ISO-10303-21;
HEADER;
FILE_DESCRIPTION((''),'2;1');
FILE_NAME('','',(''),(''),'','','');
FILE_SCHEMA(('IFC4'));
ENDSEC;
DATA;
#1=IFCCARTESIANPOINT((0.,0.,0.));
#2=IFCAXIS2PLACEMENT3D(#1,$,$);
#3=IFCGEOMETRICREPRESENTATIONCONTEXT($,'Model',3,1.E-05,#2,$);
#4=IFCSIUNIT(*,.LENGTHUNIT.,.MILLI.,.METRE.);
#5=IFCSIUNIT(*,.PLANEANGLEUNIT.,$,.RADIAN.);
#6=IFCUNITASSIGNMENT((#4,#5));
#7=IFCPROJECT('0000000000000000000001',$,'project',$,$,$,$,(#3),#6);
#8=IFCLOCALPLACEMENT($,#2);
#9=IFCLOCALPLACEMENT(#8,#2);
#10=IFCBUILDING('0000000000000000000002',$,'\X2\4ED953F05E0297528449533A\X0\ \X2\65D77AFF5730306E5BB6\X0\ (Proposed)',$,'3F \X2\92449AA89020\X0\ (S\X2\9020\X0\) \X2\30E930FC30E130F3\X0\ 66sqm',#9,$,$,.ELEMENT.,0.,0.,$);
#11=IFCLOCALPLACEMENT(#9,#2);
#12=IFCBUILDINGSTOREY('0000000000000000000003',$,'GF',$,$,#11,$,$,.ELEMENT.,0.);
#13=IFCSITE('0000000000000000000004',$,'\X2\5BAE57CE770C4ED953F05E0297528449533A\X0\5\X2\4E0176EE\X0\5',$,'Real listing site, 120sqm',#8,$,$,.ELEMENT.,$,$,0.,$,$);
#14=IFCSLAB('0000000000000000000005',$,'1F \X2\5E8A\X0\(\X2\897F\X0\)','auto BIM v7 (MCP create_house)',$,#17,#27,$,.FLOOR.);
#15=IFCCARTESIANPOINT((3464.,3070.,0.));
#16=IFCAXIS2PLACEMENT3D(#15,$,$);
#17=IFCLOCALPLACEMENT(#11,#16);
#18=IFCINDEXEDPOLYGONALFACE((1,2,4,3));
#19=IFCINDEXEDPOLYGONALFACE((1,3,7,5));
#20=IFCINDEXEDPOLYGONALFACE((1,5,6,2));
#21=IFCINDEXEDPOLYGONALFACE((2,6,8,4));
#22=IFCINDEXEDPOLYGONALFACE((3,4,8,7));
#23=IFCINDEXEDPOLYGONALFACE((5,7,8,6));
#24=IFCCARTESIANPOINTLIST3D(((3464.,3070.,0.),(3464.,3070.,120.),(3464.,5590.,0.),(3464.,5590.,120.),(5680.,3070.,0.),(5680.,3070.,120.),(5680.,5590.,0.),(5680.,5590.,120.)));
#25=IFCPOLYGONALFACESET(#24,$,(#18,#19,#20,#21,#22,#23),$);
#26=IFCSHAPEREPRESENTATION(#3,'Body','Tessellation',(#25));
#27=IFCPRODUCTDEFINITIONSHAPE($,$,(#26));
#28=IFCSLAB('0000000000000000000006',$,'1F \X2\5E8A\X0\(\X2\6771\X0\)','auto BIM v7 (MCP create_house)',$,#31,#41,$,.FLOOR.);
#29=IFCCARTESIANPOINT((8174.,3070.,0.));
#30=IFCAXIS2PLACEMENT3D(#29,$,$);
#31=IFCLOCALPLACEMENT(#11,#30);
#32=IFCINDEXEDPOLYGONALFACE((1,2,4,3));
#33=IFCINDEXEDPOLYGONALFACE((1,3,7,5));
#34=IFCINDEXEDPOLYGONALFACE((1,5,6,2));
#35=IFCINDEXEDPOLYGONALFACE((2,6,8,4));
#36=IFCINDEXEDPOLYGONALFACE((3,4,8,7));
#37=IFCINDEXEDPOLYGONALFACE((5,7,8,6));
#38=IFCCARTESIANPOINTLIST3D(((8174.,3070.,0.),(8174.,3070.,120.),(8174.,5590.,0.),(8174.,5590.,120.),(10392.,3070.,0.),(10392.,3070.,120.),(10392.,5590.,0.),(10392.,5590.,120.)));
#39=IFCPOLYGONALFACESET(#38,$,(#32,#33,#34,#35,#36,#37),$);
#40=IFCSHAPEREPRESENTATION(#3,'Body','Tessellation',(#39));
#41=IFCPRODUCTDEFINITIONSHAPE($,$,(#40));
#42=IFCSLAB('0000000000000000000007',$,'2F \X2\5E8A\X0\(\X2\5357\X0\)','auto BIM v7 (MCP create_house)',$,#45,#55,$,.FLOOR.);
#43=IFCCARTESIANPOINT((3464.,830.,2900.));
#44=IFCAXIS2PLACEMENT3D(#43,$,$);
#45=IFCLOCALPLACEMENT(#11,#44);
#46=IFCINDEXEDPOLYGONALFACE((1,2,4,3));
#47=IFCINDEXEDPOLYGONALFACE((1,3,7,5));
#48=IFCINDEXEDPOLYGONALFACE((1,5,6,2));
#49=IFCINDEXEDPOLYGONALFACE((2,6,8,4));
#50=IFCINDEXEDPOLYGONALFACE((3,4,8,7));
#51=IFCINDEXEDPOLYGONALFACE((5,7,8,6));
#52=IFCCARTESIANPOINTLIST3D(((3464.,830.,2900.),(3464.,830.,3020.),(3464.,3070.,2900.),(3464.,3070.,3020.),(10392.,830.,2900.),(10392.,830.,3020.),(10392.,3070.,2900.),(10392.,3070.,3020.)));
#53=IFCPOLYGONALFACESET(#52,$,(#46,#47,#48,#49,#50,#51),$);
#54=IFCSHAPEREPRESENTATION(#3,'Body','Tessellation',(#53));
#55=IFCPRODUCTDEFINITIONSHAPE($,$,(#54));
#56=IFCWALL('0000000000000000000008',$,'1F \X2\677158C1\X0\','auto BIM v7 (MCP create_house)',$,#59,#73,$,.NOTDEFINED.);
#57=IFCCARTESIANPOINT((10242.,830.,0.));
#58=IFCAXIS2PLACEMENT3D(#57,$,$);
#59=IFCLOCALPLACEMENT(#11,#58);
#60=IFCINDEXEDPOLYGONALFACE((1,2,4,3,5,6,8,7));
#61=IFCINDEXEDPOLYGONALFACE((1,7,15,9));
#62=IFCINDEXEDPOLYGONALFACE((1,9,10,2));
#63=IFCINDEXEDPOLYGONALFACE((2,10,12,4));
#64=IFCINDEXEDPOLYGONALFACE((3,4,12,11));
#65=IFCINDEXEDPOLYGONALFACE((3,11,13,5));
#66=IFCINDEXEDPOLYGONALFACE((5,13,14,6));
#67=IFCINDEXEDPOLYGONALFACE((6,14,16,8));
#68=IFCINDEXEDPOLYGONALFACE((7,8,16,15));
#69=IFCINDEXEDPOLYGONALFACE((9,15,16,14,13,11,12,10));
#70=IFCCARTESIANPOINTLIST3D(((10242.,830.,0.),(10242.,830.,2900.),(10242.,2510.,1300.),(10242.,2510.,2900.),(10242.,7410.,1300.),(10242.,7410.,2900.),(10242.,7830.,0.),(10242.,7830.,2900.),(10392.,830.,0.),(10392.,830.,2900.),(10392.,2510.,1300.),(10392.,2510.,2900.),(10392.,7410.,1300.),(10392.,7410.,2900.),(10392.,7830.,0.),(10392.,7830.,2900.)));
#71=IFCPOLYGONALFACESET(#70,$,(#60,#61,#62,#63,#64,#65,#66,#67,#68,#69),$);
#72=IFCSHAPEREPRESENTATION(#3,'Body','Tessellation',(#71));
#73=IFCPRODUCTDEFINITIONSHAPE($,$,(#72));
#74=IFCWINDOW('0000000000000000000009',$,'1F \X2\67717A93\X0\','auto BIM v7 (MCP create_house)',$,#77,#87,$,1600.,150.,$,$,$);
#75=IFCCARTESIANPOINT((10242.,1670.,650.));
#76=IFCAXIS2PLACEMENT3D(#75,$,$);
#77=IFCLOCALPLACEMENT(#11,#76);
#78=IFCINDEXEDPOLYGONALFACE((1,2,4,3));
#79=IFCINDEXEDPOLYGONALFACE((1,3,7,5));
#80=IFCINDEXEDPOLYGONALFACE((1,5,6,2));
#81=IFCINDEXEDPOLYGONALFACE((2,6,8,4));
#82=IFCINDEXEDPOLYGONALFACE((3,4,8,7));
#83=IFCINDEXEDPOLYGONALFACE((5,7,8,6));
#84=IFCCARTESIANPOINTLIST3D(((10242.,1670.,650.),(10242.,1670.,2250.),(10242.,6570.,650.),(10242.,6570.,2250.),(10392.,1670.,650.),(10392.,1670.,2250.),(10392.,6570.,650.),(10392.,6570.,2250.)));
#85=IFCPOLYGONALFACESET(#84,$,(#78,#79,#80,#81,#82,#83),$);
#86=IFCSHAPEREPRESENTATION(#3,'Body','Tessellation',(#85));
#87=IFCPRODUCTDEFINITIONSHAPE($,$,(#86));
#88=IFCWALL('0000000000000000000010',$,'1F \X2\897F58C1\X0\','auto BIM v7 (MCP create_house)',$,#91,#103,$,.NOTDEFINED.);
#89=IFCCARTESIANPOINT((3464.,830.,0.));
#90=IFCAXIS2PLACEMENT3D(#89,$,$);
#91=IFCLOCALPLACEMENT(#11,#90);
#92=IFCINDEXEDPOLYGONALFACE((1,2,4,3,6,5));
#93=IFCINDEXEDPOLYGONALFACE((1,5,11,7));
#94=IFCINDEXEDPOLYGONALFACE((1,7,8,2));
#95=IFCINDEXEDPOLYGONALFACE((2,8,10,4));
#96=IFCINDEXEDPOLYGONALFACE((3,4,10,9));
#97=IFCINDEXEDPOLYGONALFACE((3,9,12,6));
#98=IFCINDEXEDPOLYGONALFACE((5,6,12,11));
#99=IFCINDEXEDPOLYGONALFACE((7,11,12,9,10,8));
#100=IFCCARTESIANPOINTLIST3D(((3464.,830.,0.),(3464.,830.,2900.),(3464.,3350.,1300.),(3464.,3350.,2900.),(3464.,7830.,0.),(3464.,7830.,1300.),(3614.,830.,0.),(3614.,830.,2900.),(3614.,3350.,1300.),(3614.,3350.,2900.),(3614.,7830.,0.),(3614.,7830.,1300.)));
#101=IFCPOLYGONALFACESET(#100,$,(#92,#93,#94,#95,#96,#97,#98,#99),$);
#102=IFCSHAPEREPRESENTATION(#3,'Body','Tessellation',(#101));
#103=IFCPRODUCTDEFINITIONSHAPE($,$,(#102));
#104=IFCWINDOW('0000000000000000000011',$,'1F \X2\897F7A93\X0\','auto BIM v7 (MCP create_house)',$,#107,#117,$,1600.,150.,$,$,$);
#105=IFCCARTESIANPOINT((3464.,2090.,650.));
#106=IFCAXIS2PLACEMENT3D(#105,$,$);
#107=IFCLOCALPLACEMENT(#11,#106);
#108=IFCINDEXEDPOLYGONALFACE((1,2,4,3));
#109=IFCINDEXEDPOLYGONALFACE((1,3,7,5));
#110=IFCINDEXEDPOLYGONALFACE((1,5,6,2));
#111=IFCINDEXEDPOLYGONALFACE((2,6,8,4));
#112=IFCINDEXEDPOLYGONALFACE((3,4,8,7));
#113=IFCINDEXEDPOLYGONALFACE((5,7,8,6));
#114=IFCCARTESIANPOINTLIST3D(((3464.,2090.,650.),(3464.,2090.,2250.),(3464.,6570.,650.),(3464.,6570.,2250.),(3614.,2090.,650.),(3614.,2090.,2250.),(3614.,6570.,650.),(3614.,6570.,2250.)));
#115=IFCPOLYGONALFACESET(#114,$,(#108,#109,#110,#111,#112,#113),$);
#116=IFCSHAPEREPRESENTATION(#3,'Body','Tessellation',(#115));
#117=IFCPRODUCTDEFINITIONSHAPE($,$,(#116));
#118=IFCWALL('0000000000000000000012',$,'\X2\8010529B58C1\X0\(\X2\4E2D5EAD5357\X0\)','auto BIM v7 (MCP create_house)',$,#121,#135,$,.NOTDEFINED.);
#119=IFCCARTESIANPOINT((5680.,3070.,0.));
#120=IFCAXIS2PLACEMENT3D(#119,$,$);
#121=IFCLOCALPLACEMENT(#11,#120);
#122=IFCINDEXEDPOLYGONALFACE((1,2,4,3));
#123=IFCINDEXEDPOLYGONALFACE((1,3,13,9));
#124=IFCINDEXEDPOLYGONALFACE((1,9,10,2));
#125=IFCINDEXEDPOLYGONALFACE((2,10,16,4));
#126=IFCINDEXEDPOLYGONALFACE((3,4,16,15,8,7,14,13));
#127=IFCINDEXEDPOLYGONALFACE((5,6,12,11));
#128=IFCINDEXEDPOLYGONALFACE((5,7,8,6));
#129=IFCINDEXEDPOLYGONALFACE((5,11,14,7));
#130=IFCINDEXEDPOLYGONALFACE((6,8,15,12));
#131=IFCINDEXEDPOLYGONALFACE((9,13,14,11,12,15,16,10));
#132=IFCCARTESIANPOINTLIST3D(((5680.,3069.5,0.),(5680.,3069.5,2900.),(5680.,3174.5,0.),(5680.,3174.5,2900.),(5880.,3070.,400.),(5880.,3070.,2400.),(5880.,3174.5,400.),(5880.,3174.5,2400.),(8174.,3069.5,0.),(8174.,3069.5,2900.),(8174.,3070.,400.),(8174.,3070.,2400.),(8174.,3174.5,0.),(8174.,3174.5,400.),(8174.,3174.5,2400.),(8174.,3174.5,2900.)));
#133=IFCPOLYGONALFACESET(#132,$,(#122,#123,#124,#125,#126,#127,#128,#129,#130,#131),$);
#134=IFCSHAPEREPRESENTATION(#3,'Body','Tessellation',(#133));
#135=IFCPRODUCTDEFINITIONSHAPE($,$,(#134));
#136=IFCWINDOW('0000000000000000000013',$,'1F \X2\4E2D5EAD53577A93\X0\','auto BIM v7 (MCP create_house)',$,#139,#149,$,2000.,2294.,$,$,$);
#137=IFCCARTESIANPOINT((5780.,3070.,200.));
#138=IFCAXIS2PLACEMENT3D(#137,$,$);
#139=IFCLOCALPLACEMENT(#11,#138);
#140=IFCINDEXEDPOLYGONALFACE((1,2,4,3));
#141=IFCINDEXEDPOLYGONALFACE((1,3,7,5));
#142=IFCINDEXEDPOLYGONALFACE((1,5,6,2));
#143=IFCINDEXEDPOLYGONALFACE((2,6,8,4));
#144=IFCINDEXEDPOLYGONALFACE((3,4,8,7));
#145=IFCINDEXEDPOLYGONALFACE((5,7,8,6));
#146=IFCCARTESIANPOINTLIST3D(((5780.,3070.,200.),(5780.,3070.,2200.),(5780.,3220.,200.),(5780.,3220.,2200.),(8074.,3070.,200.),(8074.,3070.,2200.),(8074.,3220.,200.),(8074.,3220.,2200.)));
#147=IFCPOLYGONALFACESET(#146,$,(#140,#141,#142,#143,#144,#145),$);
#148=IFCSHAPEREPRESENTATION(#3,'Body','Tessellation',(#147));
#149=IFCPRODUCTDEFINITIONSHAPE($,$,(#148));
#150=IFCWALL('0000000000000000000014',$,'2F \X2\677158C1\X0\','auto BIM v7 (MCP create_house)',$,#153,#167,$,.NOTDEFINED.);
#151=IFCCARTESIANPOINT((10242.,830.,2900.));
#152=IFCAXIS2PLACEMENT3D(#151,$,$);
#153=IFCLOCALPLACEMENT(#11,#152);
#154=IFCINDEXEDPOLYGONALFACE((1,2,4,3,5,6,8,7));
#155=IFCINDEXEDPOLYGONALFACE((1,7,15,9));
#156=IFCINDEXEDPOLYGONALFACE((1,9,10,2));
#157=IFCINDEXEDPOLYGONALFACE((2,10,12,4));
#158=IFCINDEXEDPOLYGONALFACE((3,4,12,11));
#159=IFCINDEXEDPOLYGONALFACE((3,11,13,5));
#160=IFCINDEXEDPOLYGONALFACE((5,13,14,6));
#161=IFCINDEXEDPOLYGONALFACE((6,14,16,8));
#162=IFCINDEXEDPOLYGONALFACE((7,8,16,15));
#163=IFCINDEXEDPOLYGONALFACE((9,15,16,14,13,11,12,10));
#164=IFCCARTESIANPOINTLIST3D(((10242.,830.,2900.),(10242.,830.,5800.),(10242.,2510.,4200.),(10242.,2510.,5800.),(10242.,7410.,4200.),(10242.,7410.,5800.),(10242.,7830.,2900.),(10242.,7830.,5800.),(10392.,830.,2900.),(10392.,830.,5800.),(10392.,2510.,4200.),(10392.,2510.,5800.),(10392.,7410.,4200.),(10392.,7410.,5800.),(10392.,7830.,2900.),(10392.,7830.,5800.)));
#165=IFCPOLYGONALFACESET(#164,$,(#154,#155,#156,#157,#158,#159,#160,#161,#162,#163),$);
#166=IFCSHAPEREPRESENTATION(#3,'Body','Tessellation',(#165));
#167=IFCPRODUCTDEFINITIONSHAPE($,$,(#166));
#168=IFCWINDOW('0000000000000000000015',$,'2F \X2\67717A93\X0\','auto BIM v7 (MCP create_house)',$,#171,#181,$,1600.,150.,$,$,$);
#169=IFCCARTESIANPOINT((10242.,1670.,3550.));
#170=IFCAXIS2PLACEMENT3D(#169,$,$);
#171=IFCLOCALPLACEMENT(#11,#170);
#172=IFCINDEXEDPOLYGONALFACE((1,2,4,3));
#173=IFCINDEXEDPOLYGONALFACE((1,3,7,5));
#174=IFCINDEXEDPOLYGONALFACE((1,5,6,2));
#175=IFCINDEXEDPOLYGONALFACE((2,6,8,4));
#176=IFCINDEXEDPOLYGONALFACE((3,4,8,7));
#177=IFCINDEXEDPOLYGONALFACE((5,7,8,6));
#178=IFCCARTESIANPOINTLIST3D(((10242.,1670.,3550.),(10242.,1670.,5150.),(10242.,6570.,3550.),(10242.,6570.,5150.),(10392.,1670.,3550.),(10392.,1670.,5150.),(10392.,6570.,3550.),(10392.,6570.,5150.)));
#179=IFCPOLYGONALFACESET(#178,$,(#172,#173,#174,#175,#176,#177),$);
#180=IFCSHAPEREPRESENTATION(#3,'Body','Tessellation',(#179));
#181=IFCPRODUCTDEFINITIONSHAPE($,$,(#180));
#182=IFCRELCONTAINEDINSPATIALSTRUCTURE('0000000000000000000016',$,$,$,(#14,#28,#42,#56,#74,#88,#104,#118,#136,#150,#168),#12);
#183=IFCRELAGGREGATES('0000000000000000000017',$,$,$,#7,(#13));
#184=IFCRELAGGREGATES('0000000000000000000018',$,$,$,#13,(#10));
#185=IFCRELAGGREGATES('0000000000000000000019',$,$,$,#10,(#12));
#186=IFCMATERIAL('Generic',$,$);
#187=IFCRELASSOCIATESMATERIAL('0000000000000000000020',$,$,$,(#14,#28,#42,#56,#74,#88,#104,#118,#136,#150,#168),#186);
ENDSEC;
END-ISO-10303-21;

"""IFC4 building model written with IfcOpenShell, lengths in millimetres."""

from ifc_helpers import new_model, si_unit, frame, frame_2d, origin, place, context, project, spatial, rectangle, extrude, material, element, fill, save


model = new_model("IFC4")

# Units and contexts
model_context = context("Model", 3, precision=1e-05, world=origin())
ifc_project = project(units=[si_unit("LENGTHUNIT", "METRE", prefix="MILLI"), si_unit("PLANEANGLEUNIT", "RADIAN")], contexts=[model_context])

# Site, building, storey
site_placement = place(None, origin())
site = spatial("IfcSite", under=ifc_project, at=site_placement, Name="宮城県仙台市青葉区5丁目5", ObjectType="Real listing site, 120sqm", CompositionType="ELEMENT", RefElevation=0.0)
building_placement = place(site_placement, origin())
building = spatial("IfcBuilding", under=site, at=building_placement, Name="仙台市青葉区 旗竿地の家 (Proposed)", ObjectType="3F 鉄骨造 (S造) ラーメン 66sqm", CompositionType="ELEMENT", ElevationOfRefHeight=0.0, ElevationOfTerrain=0.0)
storey_placement = place(building_placement, origin())
storey = spatial("IfcBuildingStorey", under=building, at=storey_placement, Name="GF", CompositionType="ELEMENT", Elevation=0.0)

# Slabs
ifc_material = material(Name="Generic")
slab_1_placement = place(storey_placement, frame((3464.0, 3070.0, 0.0)))
element("IfcSlab", 1, at=slab_1_placement, inside=storey, material=ifc_material, Name="1F 床(西)", Description="auto BIM v7 (MCP create_house)", PredefinedType="FLOOR", context=model_context, shape_type="SweptSolid", body=[
    extrude(rectangle(XDim=2216.0, YDim=2520.0, at=frame_2d((1108.0, 1260.0))), frame((3464.0, 3070.0, 0.0)), (0.0, 0.0, 1.0), 120.0),
])
slab_2_placement = place(storey_placement, frame((8174.0, 3070.0, 0.0)))
element("IfcSlab", 2, at=slab_2_placement, inside=storey, material=ifc_material, Name="1F 床(東)", Description="auto BIM v7 (MCP create_house)", PredefinedType="FLOOR", context=model_context, shape_type="SweptSolid", body=[
    extrude(rectangle(XDim=2218.0, YDim=2520.0, at=frame_2d((1109.0, 1260.0))), frame((8174.0, 3070.0, 0.0)), (0.0, 0.0, 1.0), 120.0),
])
slab_3_placement = place(storey_placement, frame((3464.0, 830.0, 2900.0)))
element("IfcSlab", 3, at=slab_3_placement, inside=storey, material=ifc_material, Name="2F 床(南)", Description="auto BIM v7 (MCP create_house)", PredefinedType="FLOOR", context=model_context, shape_type="SweptSolid", body=[
    extrude(rectangle(XDim=6928.0, YDim=2240.0, at=frame_2d((3464.0, 1120.0))), frame((3464.0, 830.0, 2900.0)), (0.0, 0.0, 1.0), 120.0),
])

# Walls, openings, windows
wall_1_placement = place(storey_placement, frame((10242.0, 830.0, 0.0)))
wall_1 = element("IfcWall", 4, at=wall_1_placement, inside=storey, material=ifc_material, Name="1F 東壁", Description="auto BIM v7 (MCP create_house)", PredefinedType="NOTDEFINED", context=model_context, shape_type="SweptSolid", body=[
    extrude(rectangle(XDim=150.0, YDim=7000.0, at=frame_2d((75.0, 3500.0))), frame((10242.0, 830.0, 0.0)), (0.0, 0.0, 1.0), 2900.0),
])
opening_1_placement = place(storey_placement, frame((10242.0, 1670.0, 650.0)))
opening_1 = element("IfcOpeningElement", 5, at=opening_1_placement, cuts=wall_1, PredefinedType="NOTDEFINED", context=model_context, shape_type="SweptSolid", body=[
    extrude(rectangle(XDim=150.0, YDim=4900.0, at=frame_2d((75.0, 2450.0))), frame((10242.0, 1670.0, 650.0)), (0.0, 0.0, 1.0), 1600.0),
])
window_1_placement = place(storey_placement, frame((10242.0, 1670.0, 650.0)))
window_1 = element("IfcWindow", 6, at=window_1_placement, inside=storey, material=ifc_material, Name="1F 東窓", Description="auto BIM v7 (MCP create_house)", OverallHeight=1600.0, OverallWidth=150.0, context=model_context, shape_type="SweptSolid", body=[
    extrude(rectangle(XDim=150.0, YDim=4900.0, at=frame_2d((75.0, 2450.0))), frame((10242.0, 1670.0, 650.0)), (0.0, 0.0, 1.0), 1600.0),
])
fill(opening_1, window_1)
wall_2_placement = place(storey_placement, frame((3464.0, 830.0, 0.0)))
wall_2 = element("IfcWall", 7, at=wall_2_placement, inside=storey, material=ifc_material, Name="1F 西壁", Description="auto BIM v7 (MCP create_house)", PredefinedType="NOTDEFINED", context=model_context, shape_type="SweptSolid", body=[
    extrude(rectangle(XDim=150.0, YDim=7000.0, at=frame_2d((75.0, 3500.0))), frame((3464.0, 830.0, 0.0)), (0.0, 0.0, 1.0), 2900.0),
])
opening_2_placement = place(storey_placement, frame((3464.0, 2090.0, 650.0)))
opening_2 = element("IfcOpeningElement", 8, at=opening_2_placement, cuts=wall_2, PredefinedType="NOTDEFINED", context=model_context, shape_type="SweptSolid", body=[
    extrude(rectangle(XDim=150.0, YDim=4480.0, at=frame_2d((75.0, 2240.0))), frame((3464.0, 2090.0, 650.0)), (0.0, 0.0, 1.0), 1600.0),
])
window_2_placement = place(storey_placement, frame((3464.0, 2090.0, 650.0)))
window_2 = element("IfcWindow", 9, at=window_2_placement, inside=storey, material=ifc_material, Name="1F 西窓", Description="auto BIM v7 (MCP create_house)", OverallHeight=1600.0, OverallWidth=150.0, context=model_context, shape_type="SweptSolid", body=[
    extrude(rectangle(XDim=150.0, YDim=4480.0, at=frame_2d((75.0, 2240.0))), frame((3464.0, 2090.0, 650.0)), (0.0, 0.0, 1.0), 1600.0),
])
fill(opening_2, window_2)
wall_3_placement = place(storey_placement, frame((5680.0, 3070.0, 0.0)))
wall_3 = element("IfcWall", 10, at=wall_3_placement, inside=storey, material=ifc_material, Name="耐力壁(中庭南)", Description="auto BIM v7 (MCP create_house)", PredefinedType="NOTDEFINED", context=model_context, shape_type="SweptSolid", body=[
    extrude(rectangle(XDim=2494.0, YDim=105.0, at=frame_2d((1247.0, 52.0))), frame((5680.0, 3070.0, 0.0)), (0.0, 0.0, 1.0), 2900.0),
])
opening_3_placement = place(storey_placement, frame((5780.0, 3070.0, 200.0)))
opening_3 = element("IfcOpeningElement", 11, at=opening_3_placement, cuts=wall_3, PredefinedType="NOTDEFINED", context=model_context, shape_type="SweptSolid", body=[
    extrude(rectangle(XDim=2294.0, YDim=150.0, at=frame_2d((1147.0, 75.0))), frame((5780.0, 3070.0, 200.0)), (0.0, 0.0, 1.0), 2000.0),
])
window_3_placement = place(storey_placement, frame((5780.0, 3070.0, 200.0)))
window_3 = element("IfcWindow", 12, at=window_3_placement, inside=storey, material=ifc_material, Name="1F 中庭南窓", Description="auto BIM v7 (MCP create_house)", OverallHeight=2000.0, OverallWidth=2294.0, context=model_context, shape_type="SweptSolid", body=[
    extrude(rectangle(XDim=2294.0, YDim=150.0, at=frame_2d((1147.0, 75.0))), frame((5780.0, 3070.0, 200.0)), (0.0, 0.0, 1.0), 2000.0),
])
fill(opening_3, window_3)
wall_4_placement = place(storey_placement, frame((10242.0, 830.0, 2900.0)))
wall_4 = element("IfcWall", 13, at=wall_4_placement, inside=storey, material=ifc_material, Name="2F 東壁", Description="auto BIM v7 (MCP create_house)", PredefinedType="NOTDEFINED", context=model_context, shape_type="SweptSolid", body=[
    extrude(rectangle(XDim=150.0, YDim=7000.0, at=frame_2d((75.0, 3500.0))), frame((10242.0, 830.0, 2900.0)), (0.0, 0.0, 1.0), 2900.0),
])
opening_4_placement = place(storey_placement, frame((10242.0, 1670.0, 3550.0)))
opening_4 = element("IfcOpeningElement", 14, at=opening_4_placement, cuts=wall_4, PredefinedType="NOTDEFINED", context=model_context, shape_type="SweptSolid", body=[
    extrude(rectangle(XDim=150.0, YDim=4900.0, at=frame_2d((75.0, 2450.0))), frame((10242.0, 1670.0, 3550.0)), (0.0, 0.0, 1.0), 1600.0),
])
window_4_placement = place(storey_placement, frame((10242.0, 1670.0, 3550.0)))
window_4 = element("IfcWindow", 15, at=window_4_placement, inside=storey, material=ifc_material, Name="2F 東窓", Description="auto BIM v7 (MCP create_house)", OverallHeight=1600.0, OverallWidth=150.0, context=model_context, shape_type="SweptSolid", body=[
    extrude(rectangle(XDim=150.0, YDim=4900.0, at=frame_2d((75.0, 2450.0))), frame((10242.0, 1670.0, 3550.0)), (0.0, 0.0, 1.0), 1600.0),
])
fill(opening_4, window_4)

save(model, "model.ifc")
